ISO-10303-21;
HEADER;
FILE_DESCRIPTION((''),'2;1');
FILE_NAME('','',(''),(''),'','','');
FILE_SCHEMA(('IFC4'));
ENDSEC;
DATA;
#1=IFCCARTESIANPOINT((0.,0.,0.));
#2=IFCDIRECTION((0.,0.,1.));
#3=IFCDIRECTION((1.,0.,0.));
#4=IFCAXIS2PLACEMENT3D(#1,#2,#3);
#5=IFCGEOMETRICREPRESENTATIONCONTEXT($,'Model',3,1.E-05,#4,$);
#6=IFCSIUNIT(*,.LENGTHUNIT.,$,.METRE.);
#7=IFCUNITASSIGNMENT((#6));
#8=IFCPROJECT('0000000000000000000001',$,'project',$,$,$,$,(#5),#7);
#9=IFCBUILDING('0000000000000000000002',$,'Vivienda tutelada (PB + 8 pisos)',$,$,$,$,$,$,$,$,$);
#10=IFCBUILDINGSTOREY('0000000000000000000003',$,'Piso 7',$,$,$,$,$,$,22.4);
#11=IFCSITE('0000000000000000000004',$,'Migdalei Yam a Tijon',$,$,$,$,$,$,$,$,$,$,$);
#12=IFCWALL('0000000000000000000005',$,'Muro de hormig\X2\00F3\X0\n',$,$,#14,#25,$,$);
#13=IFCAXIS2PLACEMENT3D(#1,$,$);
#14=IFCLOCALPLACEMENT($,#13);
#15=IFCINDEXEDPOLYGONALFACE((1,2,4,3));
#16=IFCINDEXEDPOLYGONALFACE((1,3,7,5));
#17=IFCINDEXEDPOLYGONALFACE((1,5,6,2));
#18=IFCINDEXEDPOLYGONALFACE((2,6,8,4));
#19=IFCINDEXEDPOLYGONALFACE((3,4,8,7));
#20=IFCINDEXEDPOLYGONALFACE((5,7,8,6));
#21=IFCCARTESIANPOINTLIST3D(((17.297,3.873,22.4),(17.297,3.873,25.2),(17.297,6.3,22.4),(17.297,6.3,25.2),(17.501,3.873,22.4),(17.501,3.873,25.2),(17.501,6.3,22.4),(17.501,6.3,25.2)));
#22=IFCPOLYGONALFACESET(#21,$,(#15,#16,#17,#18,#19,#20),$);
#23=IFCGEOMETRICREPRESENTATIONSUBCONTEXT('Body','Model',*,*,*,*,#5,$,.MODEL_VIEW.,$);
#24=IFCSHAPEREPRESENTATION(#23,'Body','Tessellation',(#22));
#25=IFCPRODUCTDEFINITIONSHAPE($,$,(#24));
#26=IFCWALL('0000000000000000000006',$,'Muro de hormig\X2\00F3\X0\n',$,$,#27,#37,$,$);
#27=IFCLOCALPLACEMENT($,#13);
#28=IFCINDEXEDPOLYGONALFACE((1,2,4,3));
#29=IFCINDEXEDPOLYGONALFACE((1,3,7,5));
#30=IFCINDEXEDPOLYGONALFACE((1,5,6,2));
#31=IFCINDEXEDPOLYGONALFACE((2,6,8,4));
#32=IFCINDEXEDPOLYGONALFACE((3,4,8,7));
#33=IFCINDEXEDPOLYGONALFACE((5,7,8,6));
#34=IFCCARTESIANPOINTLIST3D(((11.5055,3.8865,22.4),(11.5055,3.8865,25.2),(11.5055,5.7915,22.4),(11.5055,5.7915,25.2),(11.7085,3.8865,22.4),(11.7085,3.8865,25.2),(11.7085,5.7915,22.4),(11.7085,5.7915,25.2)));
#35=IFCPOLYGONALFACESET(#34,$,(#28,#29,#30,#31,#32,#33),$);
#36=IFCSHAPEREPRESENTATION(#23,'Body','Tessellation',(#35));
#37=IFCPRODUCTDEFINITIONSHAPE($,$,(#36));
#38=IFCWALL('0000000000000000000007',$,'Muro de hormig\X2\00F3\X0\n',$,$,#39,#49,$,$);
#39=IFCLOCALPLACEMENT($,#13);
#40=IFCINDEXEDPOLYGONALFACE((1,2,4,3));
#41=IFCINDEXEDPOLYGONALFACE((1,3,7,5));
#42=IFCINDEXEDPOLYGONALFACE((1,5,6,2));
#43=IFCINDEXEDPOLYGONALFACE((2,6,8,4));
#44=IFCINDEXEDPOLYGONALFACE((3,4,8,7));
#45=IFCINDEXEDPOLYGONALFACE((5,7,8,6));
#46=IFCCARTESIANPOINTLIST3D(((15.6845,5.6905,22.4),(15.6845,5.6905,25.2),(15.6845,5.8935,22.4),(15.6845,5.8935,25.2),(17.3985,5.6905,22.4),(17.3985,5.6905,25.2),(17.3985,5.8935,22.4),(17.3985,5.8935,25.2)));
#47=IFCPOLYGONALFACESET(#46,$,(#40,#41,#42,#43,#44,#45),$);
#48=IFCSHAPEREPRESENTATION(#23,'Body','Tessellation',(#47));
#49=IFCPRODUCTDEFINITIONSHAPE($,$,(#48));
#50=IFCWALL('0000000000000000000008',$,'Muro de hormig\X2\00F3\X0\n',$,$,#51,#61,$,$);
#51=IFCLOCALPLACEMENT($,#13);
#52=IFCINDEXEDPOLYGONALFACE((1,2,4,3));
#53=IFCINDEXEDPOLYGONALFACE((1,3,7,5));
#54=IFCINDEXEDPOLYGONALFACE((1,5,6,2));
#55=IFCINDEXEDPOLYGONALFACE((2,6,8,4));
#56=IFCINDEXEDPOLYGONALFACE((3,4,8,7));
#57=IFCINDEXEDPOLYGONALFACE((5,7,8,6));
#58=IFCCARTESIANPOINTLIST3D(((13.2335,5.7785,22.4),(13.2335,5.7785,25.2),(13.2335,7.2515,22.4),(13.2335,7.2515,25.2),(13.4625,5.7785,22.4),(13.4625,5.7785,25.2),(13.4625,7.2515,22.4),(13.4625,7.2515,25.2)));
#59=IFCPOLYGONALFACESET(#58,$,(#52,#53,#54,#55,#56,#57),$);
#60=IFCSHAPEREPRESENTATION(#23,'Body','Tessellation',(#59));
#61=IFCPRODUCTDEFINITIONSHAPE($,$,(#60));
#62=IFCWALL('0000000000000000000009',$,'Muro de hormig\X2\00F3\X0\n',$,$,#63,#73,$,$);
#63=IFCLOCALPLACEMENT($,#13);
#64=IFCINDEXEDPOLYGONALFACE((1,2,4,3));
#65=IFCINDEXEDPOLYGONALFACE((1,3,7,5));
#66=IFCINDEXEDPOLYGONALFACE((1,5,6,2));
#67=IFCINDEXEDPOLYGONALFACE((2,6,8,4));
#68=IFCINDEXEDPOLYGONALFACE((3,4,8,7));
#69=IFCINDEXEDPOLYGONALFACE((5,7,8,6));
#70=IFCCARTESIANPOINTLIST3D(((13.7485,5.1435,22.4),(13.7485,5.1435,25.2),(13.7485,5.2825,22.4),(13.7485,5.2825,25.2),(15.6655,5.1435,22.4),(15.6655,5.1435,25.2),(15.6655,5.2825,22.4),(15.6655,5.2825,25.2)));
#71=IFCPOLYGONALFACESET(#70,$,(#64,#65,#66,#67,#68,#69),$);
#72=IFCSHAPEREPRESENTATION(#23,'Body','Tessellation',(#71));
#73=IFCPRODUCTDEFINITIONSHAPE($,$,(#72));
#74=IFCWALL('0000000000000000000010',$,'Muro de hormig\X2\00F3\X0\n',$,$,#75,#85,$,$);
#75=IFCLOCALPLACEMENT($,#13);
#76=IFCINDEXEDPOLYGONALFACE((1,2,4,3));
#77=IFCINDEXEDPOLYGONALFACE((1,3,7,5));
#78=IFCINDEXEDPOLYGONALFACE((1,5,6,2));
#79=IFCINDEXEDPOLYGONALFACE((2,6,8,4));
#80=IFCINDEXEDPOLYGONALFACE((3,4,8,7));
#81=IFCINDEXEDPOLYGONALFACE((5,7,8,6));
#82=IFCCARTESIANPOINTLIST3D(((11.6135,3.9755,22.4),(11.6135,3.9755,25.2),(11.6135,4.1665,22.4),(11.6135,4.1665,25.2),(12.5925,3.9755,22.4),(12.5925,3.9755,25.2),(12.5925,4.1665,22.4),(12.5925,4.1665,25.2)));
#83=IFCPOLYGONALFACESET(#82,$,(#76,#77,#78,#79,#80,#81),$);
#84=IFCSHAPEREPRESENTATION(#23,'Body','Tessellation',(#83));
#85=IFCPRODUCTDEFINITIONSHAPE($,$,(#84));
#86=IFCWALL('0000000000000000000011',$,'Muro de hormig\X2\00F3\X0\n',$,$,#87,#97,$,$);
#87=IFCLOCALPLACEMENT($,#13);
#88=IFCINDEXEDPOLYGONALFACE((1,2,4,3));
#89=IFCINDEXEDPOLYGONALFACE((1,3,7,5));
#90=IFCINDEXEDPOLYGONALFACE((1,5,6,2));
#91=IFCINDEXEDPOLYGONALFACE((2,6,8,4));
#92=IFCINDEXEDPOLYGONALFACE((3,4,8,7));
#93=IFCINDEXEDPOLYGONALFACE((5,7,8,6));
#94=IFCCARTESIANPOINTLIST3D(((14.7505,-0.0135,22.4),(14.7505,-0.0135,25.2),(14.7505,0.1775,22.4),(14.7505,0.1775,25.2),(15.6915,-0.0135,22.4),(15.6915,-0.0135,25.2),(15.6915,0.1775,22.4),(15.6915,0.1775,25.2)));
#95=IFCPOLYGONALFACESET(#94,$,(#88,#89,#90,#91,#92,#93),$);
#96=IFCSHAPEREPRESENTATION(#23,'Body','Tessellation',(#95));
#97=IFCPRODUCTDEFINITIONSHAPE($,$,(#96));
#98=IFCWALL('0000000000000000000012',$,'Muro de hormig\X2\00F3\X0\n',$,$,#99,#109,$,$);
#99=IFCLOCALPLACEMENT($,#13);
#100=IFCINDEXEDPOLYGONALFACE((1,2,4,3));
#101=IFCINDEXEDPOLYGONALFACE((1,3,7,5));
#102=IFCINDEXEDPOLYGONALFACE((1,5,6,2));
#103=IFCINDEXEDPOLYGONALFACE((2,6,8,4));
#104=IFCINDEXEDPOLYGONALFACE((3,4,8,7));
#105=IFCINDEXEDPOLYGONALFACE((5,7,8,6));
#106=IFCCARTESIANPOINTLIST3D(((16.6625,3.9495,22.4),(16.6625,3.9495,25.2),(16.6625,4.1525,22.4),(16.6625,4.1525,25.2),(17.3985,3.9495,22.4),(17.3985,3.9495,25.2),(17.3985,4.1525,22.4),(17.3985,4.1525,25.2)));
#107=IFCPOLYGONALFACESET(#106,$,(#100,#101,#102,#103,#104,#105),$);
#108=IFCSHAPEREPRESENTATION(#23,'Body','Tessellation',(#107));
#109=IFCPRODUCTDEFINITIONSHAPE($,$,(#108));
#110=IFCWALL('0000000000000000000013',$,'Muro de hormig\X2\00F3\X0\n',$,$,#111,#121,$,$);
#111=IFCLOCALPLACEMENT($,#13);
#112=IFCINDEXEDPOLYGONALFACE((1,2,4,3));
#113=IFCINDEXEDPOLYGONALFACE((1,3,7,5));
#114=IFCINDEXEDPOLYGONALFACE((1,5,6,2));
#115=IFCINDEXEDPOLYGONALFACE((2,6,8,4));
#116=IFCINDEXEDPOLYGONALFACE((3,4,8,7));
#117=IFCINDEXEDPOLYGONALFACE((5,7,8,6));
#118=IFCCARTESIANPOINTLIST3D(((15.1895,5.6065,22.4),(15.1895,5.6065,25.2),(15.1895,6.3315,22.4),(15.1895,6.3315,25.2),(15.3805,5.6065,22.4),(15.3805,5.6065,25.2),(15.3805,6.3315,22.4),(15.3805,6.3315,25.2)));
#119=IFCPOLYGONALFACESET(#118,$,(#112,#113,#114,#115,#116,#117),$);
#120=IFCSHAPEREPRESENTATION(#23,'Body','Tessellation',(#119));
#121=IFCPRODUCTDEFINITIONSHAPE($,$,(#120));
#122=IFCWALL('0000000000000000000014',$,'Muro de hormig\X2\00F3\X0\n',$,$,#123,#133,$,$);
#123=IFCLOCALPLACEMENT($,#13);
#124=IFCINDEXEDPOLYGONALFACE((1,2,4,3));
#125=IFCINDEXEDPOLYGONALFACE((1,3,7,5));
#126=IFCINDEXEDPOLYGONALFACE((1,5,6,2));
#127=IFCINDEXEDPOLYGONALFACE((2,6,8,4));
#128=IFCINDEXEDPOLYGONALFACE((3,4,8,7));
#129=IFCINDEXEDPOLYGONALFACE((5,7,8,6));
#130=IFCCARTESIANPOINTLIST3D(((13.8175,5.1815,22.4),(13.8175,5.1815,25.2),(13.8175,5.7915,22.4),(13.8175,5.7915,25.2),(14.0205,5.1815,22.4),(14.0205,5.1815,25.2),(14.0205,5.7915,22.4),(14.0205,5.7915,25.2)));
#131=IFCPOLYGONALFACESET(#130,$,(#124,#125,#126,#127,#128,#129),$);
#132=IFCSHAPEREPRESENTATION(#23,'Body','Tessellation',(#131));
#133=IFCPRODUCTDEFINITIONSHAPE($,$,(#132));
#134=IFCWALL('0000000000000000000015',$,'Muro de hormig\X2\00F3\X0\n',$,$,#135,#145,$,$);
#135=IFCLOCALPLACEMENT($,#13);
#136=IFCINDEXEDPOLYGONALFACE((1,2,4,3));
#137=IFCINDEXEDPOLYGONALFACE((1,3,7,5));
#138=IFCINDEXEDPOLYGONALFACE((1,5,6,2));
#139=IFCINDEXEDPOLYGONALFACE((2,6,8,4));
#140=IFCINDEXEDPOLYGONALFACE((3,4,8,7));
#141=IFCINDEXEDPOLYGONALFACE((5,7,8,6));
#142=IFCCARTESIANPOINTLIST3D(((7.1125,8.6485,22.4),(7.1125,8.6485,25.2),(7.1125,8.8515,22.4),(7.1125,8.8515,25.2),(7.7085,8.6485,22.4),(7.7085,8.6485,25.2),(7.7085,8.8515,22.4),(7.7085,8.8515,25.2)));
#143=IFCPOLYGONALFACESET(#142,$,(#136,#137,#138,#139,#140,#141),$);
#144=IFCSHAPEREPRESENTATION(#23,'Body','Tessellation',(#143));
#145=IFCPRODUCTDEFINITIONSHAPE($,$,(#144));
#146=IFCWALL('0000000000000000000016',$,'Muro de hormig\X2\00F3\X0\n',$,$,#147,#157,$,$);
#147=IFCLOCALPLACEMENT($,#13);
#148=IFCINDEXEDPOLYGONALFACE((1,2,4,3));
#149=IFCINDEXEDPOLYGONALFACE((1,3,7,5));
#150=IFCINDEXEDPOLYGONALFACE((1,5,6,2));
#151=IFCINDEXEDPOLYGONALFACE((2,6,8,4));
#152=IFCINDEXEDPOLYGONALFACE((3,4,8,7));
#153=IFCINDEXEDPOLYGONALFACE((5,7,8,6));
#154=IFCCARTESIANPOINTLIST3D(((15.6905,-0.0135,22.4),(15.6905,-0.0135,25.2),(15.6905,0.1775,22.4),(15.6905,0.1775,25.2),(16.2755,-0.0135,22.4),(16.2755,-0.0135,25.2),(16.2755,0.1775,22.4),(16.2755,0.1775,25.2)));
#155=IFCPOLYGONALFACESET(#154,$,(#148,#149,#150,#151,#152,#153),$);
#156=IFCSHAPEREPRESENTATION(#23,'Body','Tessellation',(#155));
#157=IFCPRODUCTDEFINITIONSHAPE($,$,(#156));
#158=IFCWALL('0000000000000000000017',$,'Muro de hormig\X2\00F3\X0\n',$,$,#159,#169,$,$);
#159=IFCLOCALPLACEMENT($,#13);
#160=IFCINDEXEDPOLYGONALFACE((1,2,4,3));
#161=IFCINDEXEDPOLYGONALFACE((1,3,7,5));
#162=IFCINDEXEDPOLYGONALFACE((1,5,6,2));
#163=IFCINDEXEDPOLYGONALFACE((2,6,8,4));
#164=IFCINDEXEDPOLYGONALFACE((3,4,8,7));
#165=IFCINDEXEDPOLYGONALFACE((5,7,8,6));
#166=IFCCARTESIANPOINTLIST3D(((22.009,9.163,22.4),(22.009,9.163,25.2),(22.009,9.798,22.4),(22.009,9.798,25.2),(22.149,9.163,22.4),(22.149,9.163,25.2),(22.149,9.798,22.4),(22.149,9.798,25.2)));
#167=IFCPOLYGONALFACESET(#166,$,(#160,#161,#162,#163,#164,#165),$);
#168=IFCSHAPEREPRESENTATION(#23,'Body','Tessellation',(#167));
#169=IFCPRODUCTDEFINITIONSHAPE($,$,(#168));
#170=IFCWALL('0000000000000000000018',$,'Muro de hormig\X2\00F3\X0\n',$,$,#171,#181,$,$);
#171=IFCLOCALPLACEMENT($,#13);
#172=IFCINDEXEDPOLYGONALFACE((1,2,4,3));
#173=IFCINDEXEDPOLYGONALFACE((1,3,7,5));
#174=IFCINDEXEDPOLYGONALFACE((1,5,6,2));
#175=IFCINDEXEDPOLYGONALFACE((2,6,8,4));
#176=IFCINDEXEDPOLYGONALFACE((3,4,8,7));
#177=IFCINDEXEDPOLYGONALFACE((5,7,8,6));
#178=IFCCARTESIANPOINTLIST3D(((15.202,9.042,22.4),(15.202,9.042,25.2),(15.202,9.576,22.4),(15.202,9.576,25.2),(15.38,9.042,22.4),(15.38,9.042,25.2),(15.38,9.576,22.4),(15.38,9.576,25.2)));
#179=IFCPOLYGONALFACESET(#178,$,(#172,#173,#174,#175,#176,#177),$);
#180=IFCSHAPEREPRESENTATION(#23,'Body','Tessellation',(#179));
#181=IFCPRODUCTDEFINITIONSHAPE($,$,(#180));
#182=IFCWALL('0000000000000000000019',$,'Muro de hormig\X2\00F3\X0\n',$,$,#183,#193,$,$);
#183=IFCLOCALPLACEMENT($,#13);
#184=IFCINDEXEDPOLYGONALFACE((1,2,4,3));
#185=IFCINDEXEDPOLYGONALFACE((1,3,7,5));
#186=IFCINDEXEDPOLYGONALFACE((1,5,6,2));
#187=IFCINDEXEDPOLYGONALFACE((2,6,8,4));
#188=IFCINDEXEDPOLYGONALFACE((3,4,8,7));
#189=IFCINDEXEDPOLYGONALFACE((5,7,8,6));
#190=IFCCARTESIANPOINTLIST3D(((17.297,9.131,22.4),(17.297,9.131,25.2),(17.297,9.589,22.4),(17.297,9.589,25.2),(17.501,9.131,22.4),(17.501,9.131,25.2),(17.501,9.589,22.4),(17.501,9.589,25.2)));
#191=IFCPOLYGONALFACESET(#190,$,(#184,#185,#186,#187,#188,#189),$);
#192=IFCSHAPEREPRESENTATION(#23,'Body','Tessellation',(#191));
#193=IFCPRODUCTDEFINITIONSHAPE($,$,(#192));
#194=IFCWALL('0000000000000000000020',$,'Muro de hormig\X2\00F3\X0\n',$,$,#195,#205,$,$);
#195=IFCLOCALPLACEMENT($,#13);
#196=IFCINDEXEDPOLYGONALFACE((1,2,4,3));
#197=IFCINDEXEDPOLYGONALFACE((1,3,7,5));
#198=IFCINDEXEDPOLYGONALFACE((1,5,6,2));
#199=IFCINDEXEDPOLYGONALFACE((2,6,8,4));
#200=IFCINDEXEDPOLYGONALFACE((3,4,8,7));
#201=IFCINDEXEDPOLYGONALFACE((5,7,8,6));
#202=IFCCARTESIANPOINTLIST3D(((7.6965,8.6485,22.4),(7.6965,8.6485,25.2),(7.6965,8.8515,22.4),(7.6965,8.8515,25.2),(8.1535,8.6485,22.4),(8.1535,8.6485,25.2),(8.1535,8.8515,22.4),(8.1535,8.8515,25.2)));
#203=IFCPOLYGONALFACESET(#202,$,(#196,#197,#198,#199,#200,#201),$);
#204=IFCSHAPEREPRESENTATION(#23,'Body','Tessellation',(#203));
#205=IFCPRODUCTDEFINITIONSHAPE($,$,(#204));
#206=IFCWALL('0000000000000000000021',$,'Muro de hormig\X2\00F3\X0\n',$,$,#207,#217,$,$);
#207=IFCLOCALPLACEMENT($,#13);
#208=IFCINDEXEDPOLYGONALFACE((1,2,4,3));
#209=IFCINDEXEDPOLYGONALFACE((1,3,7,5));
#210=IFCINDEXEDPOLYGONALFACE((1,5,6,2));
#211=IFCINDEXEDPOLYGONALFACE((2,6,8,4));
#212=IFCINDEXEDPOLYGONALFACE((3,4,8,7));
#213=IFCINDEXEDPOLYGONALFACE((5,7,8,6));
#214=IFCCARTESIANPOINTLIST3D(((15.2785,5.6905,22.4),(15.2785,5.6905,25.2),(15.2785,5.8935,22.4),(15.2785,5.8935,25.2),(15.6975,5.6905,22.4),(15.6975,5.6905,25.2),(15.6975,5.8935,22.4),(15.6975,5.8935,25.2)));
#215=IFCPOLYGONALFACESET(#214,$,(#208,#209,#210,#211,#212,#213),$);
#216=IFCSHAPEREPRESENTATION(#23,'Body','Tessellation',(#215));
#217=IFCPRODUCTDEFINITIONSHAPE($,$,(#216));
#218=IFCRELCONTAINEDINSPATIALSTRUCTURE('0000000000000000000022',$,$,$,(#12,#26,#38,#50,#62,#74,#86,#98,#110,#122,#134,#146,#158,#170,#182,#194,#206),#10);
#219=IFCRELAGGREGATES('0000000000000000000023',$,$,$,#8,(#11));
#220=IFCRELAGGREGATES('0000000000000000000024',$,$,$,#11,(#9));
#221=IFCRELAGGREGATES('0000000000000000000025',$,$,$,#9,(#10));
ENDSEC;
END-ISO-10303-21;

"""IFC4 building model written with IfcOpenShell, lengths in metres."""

from ifc_helpers import new_model, si_unit, frame, origin_with_axes, context, subcontext, project, spatial, line, indexed_curve, outline, extrude, element, save


model = new_model("IFC4")

# Units and contexts
model_context = context("Model", 3, precision=1e-05, world=origin_with_axes())
body_context = subcontext(model_context, "Body", "Model", "MODEL_VIEW")
ifc_project = project(units=[si_unit("LENGTHUNIT", "METRE")], contexts=[model_context])

# Site, building, storey
site = spatial("IfcSite", under=ifc_project, Name="Migdalei Yam a Tijon")
building = spatial("IfcBuilding", under=site, Name="Vivienda tutelada (PB + 8 pisos)")
storey = spatial("IfcBuildingStorey", under=building, Name="Piso 7", Elevation=22.4)

# Walls
element("IfcWall", 1, inside=storey, Name="Muro de hormigón", context=body_context, shape_type="SweptSolid", body=[
    extrude(outline(indexed_curve([(0.0, 0.0), (0.204, 0.0), (0.204, 2.427), (0.0, 2.427)], segments=[line(1, 2, 3, 4, 1)])), frame((17.297, 3.873, 22.4), z_axis=(0.0, 0.0, 1.0), x_axis=(1.0, 0.0, 0.0)), (0.0, 0.0, 1.0), 2.8),
])
element("IfcWall", 2, inside=storey, Name="Muro de hormigón", context=body_context, shape_type="SweptSolid", body=[
    extrude(outline(indexed_curve([(0.0, 0.0), (0.203, 0.0), (0.203, 1.905), (0.0, 1.905)], segments=[line(1, 2, 3, 4, 1)])), frame((11.5055, 3.8865, 22.4), z_axis=(0.0, 0.0, 1.0), x_axis=(1.0, 0.0, 0.0)), (0.0, 0.0, 1.0), 2.8),
])
element("IfcWall", 3, inside=storey, Name="Muro de hormigón", context=body_context, shape_type="SweptSolid", body=[
    extrude(outline(indexed_curve([(0.0, 0.0), (1.714, 0.0), (1.714, 0.203), (0.0, 0.203)], segments=[line(1, 2, 3, 4, 1)])), frame((15.6845, 5.6905, 22.4), z_axis=(0.0, 0.0, 1.0), x_axis=(1.0, 0.0, 0.0)), (0.0, 0.0, 1.0), 2.8),
])
element("IfcWall", 4, inside=storey, Name="Muro de hormigón", context=body_context, shape_type="SweptSolid", body=[
    extrude(outline(indexed_curve([(0.0, 0.0), (0.229, 0.0), (0.229, 1.473), (0.0, 1.473)], segments=[line(1, 2, 3, 4, 1)])), frame((13.2335, 5.7785, 22.4), z_axis=(0.0, 0.0, 1.0), x_axis=(1.0, 0.0, 0.0)), (0.0, 0.0, 1.0), 2.8),
])
element("IfcWall", 5, inside=storey, Name="Muro de hormigón", context=body_context, shape_type="SweptSolid", body=[
    extrude(outline(indexed_curve([(0.0, 0.0), (1.917, 0.0), (1.917, 0.139), (0.0, 0.139)], segments=[line(1, 2, 3, 4, 1)])), frame((13.7485, 5.1435, 22.4), z_axis=(0.0, 0.0, 1.0), x_axis=(1.0, 0.0, 0.0)), (0.0, 0.0, 1.0), 2.8),
])
element("IfcWall", 6, inside=storey, Name="Muro de hormigón", context=body_context, shape_type="SweptSolid", body=[
    extrude(outline(indexed_curve([(0.0, 0.0), (0.979, 0.0), (0.979, 0.191), (0.0, 0.191)], segments=[line(1, 2, 3, 4, 1)])), frame((11.6135, 3.9755, 22.4), z_axis=(0.0, 0.0, 1.0), x_axis=(1.0, 0.0, 0.0)), (0.0, 0.0, 1.0), 2.8),
])
element("IfcWall", 7, inside=storey, Name="Muro de hormigón", context=body_context, shape_type="SweptSolid", body=[
    extrude(outline(indexed_curve([(0.0, 0.0), (0.941, 0.0), (0.941, 0.191), (0.0, 0.191)], segments=[line(1, 2, 3, 4, 1)])), frame((14.7505, -0.0135, 22.4), z_axis=(0.0, 0.0, 1.0), x_axis=(1.0, 0.0, 0.0)), (0.0, 0.0, 1.0), 2.8),
])
element("IfcWall", 8, inside=storey, Name="Muro de hormigón", context=body_context, shape_type="SweptSolid", body=[
    extrude(outline(indexed_curve([(0.0, 0.0), (0.736, 0.0), (0.736, 0.203), (0.0, 0.203)], segments=[line(1, 2, 3, 4, 1)])), frame((16.6625, 3.9495, 22.4), z_axis=(0.0, 0.0, 1.0), x_axis=(1.0, 0.0, 0.0)), (0.0, 0.0, 1.0), 2.8),
])
element("IfcWall", 9, inside=storey, Name="Muro de hormigón", context=body_context, shape_type="SweptSolid", body=[
    extrude(outline(indexed_curve([(0.0, 0.0), (0.191, 0.0), (0.191, 0.725), (0.0, 0.725)], segments=[line(1, 2, 3, 4, 1)])), frame((15.1895, 5.6065, 22.4), z_axis=(0.0, 0.0, 1.0), x_axis=(1.0, 0.0, 0.0)), (0.0, 0.0, 1.0), 2.8),
])
element("IfcWall", 10, inside=storey, Name="Muro de hormigón", context=body_context, shape_type="SweptSolid", body=[
    extrude(outline(indexed_curve([(0.0, 0.0), (0.203, 0.0), (0.203, 0.61), (0.0, 0.61)], segments=[line(1, 2, 3, 4, 1)])), frame((13.8175, 5.1815, 22.4), z_axis=(0.0, 0.0, 1.0), x_axis=(1.0, 0.0, 0.0)), (0.0, 0.0, 1.0), 2.8),
])
element("IfcWall", 11, inside=storey, Name="Muro de hormigón", context=body_context, shape_type="SweptSolid", body=[
    extrude(outline(indexed_curve([(0.0, 0.0), (0.596, 0.0), (0.596, 0.203), (0.0, 0.203)], segments=[line(1, 2, 3, 4, 1)])), frame((7.1125, 8.6485, 22.4), z_axis=(0.0, 0.0, 1.0), x_axis=(1.0, 0.0, 0.0)), (0.0, 0.0, 1.0), 2.8),
])
element("IfcWall", 12, inside=storey, Name="Muro de hormigón", context=body_context, shape_type="SweptSolid", body=[
    extrude(outline(indexed_curve([(0.0, 0.0), (0.585, 0.0), (0.585, 0.191), (0.0, 0.191)], segments=[line(1, 2, 3, 4, 1)])), frame((15.6905, -0.0135, 22.4), z_axis=(0.0, 0.0, 1.0), x_axis=(1.0, 0.0, 0.0)), (0.0, 0.0, 1.0), 2.8),
])
element("IfcWall", 13, inside=storey, Name="Muro de hormigón", context=body_context, shape_type="SweptSolid", body=[
    extrude(outline(indexed_curve([(0.0, 0.0), (0.14, 0.0), (0.14, 0.635), (0.0, 0.635)], segments=[line(1, 2, 3, 4, 1)])), frame((22.009, 9.163, 22.4), z_axis=(0.0, 0.0, 1.0), x_axis=(1.0, 0.0, 0.0)), (0.0, 0.0, 1.0), 2.8),
])
element("IfcWall", 14, inside=storey, Name="Muro de hormigón", context=body_context, shape_type="SweptSolid", body=[
    extrude(outline(indexed_curve([(0.0, 0.0), (0.178, 0.0), (0.178, 0.534), (0.0, 0.534)], segments=[line(1, 2, 3, 4, 1)])), frame((15.202, 9.042, 22.4), z_axis=(0.0, 0.0, 1.0), x_axis=(1.0, 0.0, 0.0)), (0.0, 0.0, 1.0), 2.8),
])
element("IfcWall", 15, inside=storey, Name="Muro de hormigón", context=body_context, shape_type="SweptSolid", body=[
    extrude(outline(indexed_curve([(0.0, 0.0), (0.204, 0.0), (0.204, 0.458), (0.0, 0.458)], segments=[line(1, 2, 3, 4, 1)])), frame((17.297, 9.131, 22.4), z_axis=(0.0, 0.0, 1.0), x_axis=(1.0, 0.0, 0.0)), (0.0, 0.0, 1.0), 2.8),
])
element("IfcWall", 16, inside=storey, Name="Muro de hormigón", context=body_context, shape_type="SweptSolid", body=[
    extrude(outline(indexed_curve([(0.0, 0.0), (0.457, 0.0), (0.457, 0.203), (0.0, 0.203)], segments=[line(1, 2, 3, 4, 1)])), frame((7.6965, 8.6485, 22.4), z_axis=(0.0, 0.0, 1.0), x_axis=(1.0, 0.0, 0.0)), (0.0, 0.0, 1.0), 2.8),
])
element("IfcWall", 17, inside=storey, Name="Muro de hormigón", context=body_context, shape_type="SweptSolid", body=[
    extrude(outline(indexed_curve([(0.0, 0.0), (0.419, 0.0), (0.419, 0.203), (0.0, 0.203)], segments=[line(1, 2, 3, 4, 1)])), frame((15.2785, 5.6905, 22.4), z_axis=(0.0, 0.0, 1.0), x_axis=(1.0, 0.0, 0.0)), (0.0, 0.0, 1.0), 2.8),
])

save(model, "model.ifc")
